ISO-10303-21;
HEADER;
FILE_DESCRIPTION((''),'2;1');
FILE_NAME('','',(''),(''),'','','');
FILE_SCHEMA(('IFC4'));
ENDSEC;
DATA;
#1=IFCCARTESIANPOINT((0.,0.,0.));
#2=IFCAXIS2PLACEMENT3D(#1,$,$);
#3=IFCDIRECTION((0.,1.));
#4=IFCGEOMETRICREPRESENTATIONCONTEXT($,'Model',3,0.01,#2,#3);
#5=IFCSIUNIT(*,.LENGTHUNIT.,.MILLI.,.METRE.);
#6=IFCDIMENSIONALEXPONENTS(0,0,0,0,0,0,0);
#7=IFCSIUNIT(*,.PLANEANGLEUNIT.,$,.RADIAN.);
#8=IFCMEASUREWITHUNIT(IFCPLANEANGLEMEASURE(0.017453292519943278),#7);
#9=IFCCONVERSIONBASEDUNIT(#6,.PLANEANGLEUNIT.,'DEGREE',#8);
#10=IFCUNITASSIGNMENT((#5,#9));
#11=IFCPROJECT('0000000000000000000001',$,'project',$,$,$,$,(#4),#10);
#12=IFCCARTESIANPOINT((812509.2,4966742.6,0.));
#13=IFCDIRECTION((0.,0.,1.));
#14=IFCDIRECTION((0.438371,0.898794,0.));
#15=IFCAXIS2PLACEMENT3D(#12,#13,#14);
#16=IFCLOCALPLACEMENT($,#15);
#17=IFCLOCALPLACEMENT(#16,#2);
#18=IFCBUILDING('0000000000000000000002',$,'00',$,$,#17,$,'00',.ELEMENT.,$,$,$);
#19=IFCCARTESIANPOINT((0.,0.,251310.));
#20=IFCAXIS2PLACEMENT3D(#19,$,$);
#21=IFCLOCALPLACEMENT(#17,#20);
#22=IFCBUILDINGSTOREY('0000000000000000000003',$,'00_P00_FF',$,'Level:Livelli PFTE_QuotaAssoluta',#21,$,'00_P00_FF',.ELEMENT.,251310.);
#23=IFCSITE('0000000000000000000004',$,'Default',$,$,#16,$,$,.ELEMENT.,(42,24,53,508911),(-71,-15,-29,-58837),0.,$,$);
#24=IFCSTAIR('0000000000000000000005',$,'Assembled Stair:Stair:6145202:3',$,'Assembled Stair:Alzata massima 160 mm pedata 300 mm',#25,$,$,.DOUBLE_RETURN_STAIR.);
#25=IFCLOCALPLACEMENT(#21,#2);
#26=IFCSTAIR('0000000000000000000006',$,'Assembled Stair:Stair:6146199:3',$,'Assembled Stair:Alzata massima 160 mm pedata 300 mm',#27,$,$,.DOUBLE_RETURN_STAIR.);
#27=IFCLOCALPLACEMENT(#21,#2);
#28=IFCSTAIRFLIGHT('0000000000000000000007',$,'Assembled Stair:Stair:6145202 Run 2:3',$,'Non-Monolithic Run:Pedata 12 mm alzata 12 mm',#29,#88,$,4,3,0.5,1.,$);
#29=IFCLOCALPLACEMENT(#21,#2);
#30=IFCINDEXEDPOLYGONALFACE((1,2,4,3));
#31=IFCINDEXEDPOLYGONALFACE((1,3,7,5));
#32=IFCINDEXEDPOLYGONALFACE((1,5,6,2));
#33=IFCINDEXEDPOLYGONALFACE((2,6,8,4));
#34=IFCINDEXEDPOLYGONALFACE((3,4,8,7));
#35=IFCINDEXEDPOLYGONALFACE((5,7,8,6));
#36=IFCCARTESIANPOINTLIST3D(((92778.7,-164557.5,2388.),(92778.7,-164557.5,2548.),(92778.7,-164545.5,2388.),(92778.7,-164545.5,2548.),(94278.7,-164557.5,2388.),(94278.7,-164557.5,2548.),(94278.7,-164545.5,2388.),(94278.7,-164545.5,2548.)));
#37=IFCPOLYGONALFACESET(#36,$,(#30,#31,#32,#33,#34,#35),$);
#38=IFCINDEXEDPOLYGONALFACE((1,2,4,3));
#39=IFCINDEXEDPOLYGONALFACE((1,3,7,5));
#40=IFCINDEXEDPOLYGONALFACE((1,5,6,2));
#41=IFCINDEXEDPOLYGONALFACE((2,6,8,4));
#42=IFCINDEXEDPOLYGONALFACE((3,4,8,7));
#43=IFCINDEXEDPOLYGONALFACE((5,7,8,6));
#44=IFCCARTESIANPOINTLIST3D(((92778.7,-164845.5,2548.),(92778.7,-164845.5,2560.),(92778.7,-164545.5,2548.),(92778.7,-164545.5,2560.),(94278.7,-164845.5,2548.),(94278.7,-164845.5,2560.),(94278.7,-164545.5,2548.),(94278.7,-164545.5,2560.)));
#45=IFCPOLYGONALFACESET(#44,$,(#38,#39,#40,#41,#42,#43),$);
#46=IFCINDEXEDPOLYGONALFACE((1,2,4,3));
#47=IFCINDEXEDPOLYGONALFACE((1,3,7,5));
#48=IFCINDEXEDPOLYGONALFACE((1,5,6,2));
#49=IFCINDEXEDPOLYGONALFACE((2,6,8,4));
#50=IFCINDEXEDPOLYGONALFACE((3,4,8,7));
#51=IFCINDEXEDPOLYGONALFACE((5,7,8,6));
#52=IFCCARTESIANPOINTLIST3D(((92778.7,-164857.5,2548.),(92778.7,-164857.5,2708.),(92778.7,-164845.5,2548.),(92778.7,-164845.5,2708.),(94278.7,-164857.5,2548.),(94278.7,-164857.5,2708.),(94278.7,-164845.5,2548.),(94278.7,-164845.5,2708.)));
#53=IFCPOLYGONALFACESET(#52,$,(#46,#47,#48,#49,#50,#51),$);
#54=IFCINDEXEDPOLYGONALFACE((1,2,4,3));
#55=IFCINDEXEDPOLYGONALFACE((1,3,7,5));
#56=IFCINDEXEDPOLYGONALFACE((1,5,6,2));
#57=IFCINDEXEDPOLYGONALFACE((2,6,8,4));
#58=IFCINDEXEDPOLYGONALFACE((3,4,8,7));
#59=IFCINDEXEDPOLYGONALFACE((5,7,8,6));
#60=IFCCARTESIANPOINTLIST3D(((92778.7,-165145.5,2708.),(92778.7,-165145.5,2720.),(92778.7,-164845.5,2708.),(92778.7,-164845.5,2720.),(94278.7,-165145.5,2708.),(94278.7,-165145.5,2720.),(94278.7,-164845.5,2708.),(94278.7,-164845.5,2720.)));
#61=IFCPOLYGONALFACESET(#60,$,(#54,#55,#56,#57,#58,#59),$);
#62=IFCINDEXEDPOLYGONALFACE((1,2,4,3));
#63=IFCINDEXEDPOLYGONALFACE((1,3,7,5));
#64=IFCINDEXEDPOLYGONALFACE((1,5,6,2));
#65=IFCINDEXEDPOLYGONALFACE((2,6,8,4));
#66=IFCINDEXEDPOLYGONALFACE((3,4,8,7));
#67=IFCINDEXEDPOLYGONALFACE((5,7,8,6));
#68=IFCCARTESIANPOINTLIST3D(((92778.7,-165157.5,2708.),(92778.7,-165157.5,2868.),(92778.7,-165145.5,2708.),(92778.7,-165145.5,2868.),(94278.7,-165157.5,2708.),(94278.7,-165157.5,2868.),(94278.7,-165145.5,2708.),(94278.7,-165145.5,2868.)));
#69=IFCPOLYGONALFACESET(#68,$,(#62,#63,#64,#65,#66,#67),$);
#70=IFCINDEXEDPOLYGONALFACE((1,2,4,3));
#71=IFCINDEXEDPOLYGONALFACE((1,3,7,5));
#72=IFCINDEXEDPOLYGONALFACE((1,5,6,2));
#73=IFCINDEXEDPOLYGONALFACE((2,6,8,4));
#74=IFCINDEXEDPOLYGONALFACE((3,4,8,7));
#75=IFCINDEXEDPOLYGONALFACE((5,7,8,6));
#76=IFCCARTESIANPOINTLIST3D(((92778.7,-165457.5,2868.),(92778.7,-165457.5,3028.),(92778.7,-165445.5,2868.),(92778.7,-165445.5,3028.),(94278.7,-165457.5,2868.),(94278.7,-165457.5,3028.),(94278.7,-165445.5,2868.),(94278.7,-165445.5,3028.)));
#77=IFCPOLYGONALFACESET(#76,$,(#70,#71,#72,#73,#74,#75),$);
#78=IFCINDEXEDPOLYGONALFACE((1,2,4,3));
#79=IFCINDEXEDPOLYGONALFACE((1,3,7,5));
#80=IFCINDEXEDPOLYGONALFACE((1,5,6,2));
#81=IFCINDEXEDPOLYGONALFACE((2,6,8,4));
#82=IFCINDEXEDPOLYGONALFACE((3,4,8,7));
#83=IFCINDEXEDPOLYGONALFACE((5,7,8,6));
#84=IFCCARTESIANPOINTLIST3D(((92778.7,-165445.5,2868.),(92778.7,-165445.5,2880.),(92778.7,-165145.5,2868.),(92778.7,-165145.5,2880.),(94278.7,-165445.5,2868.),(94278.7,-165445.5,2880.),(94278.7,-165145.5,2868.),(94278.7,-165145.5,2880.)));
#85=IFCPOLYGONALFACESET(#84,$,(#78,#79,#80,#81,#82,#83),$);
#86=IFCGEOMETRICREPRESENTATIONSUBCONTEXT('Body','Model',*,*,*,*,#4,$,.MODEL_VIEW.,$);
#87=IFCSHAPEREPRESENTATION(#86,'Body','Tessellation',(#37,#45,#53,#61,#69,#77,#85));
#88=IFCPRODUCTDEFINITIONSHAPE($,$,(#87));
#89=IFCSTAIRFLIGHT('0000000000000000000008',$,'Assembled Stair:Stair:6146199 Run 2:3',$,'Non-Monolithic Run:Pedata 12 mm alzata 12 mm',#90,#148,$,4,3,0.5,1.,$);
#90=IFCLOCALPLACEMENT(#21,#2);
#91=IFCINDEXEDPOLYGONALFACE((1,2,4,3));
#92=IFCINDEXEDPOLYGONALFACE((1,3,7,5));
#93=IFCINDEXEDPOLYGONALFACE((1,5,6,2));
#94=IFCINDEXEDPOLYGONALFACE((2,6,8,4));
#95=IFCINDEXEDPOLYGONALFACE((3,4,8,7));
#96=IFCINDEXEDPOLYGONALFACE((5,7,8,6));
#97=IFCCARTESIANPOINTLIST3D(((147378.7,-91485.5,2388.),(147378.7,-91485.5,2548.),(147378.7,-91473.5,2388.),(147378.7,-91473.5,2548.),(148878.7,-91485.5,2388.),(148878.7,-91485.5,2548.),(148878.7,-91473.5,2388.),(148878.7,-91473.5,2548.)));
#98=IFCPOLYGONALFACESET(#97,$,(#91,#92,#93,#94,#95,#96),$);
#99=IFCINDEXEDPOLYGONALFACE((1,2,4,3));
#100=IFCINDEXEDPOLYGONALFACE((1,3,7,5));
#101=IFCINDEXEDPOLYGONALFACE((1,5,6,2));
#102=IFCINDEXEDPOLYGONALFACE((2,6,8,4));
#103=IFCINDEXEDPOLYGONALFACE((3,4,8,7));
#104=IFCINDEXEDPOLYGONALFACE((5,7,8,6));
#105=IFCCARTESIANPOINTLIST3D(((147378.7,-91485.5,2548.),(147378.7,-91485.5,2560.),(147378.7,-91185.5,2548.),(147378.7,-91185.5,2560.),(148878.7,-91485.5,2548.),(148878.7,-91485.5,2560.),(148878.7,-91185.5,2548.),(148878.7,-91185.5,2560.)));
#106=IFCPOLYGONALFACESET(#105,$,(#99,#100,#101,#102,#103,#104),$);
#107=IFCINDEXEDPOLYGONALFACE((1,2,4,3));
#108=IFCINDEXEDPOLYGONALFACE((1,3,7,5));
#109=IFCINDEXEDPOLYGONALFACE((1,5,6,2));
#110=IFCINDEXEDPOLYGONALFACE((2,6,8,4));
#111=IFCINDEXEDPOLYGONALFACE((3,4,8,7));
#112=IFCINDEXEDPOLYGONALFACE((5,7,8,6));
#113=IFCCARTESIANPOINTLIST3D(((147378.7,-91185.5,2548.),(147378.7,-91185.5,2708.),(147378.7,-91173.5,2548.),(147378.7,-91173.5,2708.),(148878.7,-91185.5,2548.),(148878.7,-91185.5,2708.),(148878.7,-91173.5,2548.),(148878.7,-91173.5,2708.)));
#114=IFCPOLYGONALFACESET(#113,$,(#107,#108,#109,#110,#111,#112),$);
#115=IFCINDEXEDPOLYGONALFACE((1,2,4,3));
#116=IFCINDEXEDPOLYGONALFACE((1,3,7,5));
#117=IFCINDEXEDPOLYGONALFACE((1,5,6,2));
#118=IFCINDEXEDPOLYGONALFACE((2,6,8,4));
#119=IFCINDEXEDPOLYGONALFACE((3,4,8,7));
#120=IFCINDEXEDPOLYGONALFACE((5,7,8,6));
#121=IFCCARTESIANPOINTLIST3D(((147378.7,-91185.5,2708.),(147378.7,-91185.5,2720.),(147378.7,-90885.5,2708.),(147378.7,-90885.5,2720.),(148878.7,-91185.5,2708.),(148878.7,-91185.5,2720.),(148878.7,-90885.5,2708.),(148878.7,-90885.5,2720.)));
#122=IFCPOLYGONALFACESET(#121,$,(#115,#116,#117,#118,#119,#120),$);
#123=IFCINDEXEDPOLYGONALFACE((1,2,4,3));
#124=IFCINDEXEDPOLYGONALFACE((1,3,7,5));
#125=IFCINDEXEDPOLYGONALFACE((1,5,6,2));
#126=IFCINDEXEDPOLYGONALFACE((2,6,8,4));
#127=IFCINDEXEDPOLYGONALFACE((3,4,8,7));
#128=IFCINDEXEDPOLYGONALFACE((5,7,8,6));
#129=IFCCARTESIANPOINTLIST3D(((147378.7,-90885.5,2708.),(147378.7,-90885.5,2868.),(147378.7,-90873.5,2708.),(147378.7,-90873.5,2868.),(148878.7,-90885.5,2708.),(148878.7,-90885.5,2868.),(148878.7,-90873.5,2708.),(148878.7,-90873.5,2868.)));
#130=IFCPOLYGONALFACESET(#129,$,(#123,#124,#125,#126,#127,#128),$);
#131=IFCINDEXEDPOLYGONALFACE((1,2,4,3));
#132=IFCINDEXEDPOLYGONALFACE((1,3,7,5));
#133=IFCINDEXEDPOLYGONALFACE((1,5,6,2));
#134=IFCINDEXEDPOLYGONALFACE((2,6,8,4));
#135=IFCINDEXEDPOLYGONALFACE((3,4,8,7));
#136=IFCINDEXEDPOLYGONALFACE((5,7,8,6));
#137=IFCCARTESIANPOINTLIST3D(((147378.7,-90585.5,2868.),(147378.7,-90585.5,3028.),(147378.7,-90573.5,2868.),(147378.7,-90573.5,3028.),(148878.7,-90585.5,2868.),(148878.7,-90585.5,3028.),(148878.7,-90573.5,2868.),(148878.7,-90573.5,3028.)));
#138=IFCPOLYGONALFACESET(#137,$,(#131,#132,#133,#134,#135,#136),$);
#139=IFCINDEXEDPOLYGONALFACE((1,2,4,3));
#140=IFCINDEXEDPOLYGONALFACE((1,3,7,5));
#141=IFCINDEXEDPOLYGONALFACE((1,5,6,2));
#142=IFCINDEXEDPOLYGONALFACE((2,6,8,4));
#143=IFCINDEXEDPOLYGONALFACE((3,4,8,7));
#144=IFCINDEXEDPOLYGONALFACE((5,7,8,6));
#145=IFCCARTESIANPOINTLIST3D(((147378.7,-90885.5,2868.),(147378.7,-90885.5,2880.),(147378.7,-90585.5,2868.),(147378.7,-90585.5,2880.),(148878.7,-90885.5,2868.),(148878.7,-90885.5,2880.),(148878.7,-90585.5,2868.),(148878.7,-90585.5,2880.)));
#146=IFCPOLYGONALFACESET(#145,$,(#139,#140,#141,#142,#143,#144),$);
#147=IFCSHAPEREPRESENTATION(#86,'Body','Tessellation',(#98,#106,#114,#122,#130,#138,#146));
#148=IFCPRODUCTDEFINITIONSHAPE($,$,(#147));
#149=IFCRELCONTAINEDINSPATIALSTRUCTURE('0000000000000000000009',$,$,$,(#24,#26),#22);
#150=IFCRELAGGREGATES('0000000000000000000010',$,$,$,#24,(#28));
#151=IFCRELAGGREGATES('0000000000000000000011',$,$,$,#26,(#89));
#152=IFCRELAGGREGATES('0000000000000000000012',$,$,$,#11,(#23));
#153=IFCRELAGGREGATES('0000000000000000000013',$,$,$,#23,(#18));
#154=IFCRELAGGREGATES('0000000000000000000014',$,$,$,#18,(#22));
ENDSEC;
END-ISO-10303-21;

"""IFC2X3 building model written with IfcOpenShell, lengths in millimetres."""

from ifc_helpers import new_model, entity, si_unit, converted_unit, direction, frame, frame_2d, origin, origin_2d_with_axis, place, context, subcontext, project, spatial, rectangle, extrude, element, aggregate, save


model = new_model("IFC2X3")

# Units and contexts
model_context = context("Model", 3, precision=0.01, world=origin(), true_north=direction((0.0, 1.0)))
body_context = subcontext(model_context, "Body", "Model", "MODEL_VIEW")
ifc_project = project(units=[si_unit("LENGTHUNIT", "METRE", prefix="MILLI"), converted_unit("PLANEANGLEUNIT", "DEGREE", entity("IfcPlaneAngleMeasure", 0.017453292519943278), si_unit("PLANEANGLEUNIT", "RADIAN"), dimensions=[0, 0, 0, 0, 0, 0, 0])], contexts=[model_context])

# Site, building, storey
site_placement = place(None, frame((812509.2, 4966742.6, 0.0), z_axis=(0.0, 0.0, 1.0), x_axis=(0.438371, 0.898794, 0.0)))
site = spatial("IfcSite", under=ifc_project, at=site_placement, Name="Default", CompositionType="ELEMENT", RefLatitude=(42, 24, 53, 508911), RefLongitude=(-71, -15, -29, -58837), RefElevation=0.0)
building_placement = place(site_placement, origin())
building = spatial("IfcBuilding", under=site, at=building_placement, Name="00", LongName="00", CompositionType="ELEMENT")
storey_placement = place(building_placement, frame((0.0, 0.0, 251310.0)))
storey = spatial("IfcBuildingStorey", under=building, at=storey_placement, Name="00_P00_FF", ObjectType="Level:Livelli PFTE_QuotaAssoluta", LongName="00_P00_FF", CompositionType="ELEMENT", Elevation=251310.0)

# Stairs
stair_1_placement = place(storey_placement, origin())
stair_1 = element("IfcStair", 1, at=stair_1_placement, inside=storey, Name="Assembled Stair:Stair:6145202:3", ObjectType="Assembled Stair:Alzata massima 160 mm pedata 300 mm", ShapeType="DOUBLE_RETURN_STAIR")
stair_2_placement = place(storey_placement, origin())
stair_2 = element("IfcStair", 2, at=stair_2_placement, inside=storey, Name="Assembled Stair:Stair:6146199:3", ObjectType="Assembled Stair:Alzata massima 160 mm pedata 300 mm", ShapeType="DOUBLE_RETURN_STAIR")

# Stair flights
stair_flight_1_placement = place(stair_1_placement, origin())
stair_flight_1 = element("IfcStairFlight", 3, at=stair_flight_1_placement, Name="Assembled Stair:Stair:6145202 Run 2:3", ObjectType="Non-Monolithic Run:Pedata 12 mm alzata 12 mm", NumberOfRiser=4, NumberOfTreads=3, RiserHeight=0.5, TreadLength=1.0, context=body_context, shape_type="SweptSolid", body=[
    extrude(rectangle(XDim=1500.0, YDim=12.0, at=origin_2d_with_axis()), frame((93528.7, -164551.5, 2388.0)), (0.0, 0.0, 1.0), 160.0),
    extrude(rectangle(XDim=300.0, YDim=1500.0, at=origin_2d_with_axis()), frame((93528.7, -164695.5, 2548.0), z_axis=(0.0, 0.0, 1.0), x_axis=(0.0, 1.0, 0.0)), (0.0, 0.0, 1.0), 12.0),
    extrude(rectangle(XDim=1500.0, YDim=12.0, at=origin_2d_with_axis()), frame((93528.7, -164851.5, 2548.0)), (0.0, 0.0, 1.0), 160.0),
    extrude(rectangle(XDim=300.0, YDim=1500.0, at=frame_2d((0.0, 0.0), x_axis=(1.0, 0.0))), frame((93528.7, -164995.5, 2708.0), z_axis=(0.0, 0.0, 1.0), x_axis=(0.0, 1.0, 0.0)), (0.0, 0.0, 1.0), 12.0),
    extrude(rectangle(XDim=1500.0, YDim=12.0, at=origin_2d_with_axis()), frame((93528.7, -165151.5, 2708.0)), (0.0, 0.0, 1.0), 160.0),
    extrude(rectangle(XDim=1500.0, YDim=12.0, at=origin_2d_with_axis()), frame((93528.7, -165451.5, 2868.0)), (0.0, 0.0, 1.0), 160.0),
    extrude(rectangle(XDim=300.0, YDim=1500.0, at=frame_2d((0.0, 0.0), x_axis=(1.0, 0.0))), frame((93528.7, -165295.5, 2868.0), z_axis=(0.0, 0.0, 1.0), x_axis=(0.0, 1.0, 0.0)), (0.0, 0.0, 1.0), 12.0),
])
aggregate(stair_1, [stair_flight_1])
stair_flight_2_placement = place(stair_2_placement, origin())
stair_flight_2 = element("IfcStairFlight", 4, at=stair_flight_2_placement, Name="Assembled Stair:Stair:6146199 Run 2:3", ObjectType="Non-Monolithic Run:Pedata 12 mm alzata 12 mm", NumberOfRiser=4, NumberOfTreads=3, RiserHeight=0.5, TreadLength=1.0, context=body_context, shape_type="SweptSolid", body=[
    extrude(rectangle(XDim=1500.0, YDim=12.0, at=origin_2d_with_axis()), frame((148128.7, -91479.5, 2388.0), z_axis=(0.0, 0.0, 1.0), x_axis=(-1.0, 0.0, 0.0)), (0.0, 0.0, 1.0), 160.0),
    extrude(rectangle(XDim=300.0, YDim=1500.0, at=frame_2d((0.0, 0.0), x_axis=(1.0, 0.0))), frame((148128.7, -91335.5, 2548.0), z_axis=(0.0, 0.0, 1.0), x_axis=(0.0, -1.0, 0.0)), (0.0, 0.0, 1.0), 12.0),
    extrude(rectangle(XDim=1500.0, YDim=12.0, at=frame_2d((0.0, 0.0), x_axis=(1.0, 0.0))), frame((148128.7, -91179.5, 2548.0), z_axis=(0.0, 0.0, 1.0), x_axis=(-1.0, 0.0, 0.0)), (0.0, 0.0, 1.0), 160.0),
    extrude(rectangle(XDim=300.0, YDim=1500.0, at=origin_2d_with_axis()), frame((148128.7, -91035.5, 2708.0), z_axis=(0.0, 0.0, 1.0), x_axis=(0.0, -1.0, 0.0)), (0.0, 0.0, 1.0), 12.0),
    extrude(rectangle(XDim=1500.0, YDim=12.0, at=frame_2d((0.0, 0.0), x_axis=(1.0, 0.0))), frame((148128.7, -90879.5, 2708.0), z_axis=(0.0, 0.0, 1.0), x_axis=(-1.0, 0.0, 0.0)), (0.0, 0.0, 1.0), 160.0),
    extrude(rectangle(XDim=1500.0, YDim=12.0, at=origin_2d_with_axis()), frame((148128.7, -90579.5, 2868.0), z_axis=(0.0, 0.0, 1.0), x_axis=(-1.0, 0.0, 0.0)), (0.0, 0.0, 1.0), 160.0),
    extrude(rectangle(XDim=300.0, YDim=1500.0, at=origin_2d_with_axis()), frame((148128.7, -90735.5, 2868.0), z_axis=(0.0, 0.0, 1.0), x_axis=(0.0, -1.0, 0.0)), (0.0, 0.0, 1.0), 12.0),
])
aggregate(stair_2, [stair_flight_2])

save(model, "model.ifc")
